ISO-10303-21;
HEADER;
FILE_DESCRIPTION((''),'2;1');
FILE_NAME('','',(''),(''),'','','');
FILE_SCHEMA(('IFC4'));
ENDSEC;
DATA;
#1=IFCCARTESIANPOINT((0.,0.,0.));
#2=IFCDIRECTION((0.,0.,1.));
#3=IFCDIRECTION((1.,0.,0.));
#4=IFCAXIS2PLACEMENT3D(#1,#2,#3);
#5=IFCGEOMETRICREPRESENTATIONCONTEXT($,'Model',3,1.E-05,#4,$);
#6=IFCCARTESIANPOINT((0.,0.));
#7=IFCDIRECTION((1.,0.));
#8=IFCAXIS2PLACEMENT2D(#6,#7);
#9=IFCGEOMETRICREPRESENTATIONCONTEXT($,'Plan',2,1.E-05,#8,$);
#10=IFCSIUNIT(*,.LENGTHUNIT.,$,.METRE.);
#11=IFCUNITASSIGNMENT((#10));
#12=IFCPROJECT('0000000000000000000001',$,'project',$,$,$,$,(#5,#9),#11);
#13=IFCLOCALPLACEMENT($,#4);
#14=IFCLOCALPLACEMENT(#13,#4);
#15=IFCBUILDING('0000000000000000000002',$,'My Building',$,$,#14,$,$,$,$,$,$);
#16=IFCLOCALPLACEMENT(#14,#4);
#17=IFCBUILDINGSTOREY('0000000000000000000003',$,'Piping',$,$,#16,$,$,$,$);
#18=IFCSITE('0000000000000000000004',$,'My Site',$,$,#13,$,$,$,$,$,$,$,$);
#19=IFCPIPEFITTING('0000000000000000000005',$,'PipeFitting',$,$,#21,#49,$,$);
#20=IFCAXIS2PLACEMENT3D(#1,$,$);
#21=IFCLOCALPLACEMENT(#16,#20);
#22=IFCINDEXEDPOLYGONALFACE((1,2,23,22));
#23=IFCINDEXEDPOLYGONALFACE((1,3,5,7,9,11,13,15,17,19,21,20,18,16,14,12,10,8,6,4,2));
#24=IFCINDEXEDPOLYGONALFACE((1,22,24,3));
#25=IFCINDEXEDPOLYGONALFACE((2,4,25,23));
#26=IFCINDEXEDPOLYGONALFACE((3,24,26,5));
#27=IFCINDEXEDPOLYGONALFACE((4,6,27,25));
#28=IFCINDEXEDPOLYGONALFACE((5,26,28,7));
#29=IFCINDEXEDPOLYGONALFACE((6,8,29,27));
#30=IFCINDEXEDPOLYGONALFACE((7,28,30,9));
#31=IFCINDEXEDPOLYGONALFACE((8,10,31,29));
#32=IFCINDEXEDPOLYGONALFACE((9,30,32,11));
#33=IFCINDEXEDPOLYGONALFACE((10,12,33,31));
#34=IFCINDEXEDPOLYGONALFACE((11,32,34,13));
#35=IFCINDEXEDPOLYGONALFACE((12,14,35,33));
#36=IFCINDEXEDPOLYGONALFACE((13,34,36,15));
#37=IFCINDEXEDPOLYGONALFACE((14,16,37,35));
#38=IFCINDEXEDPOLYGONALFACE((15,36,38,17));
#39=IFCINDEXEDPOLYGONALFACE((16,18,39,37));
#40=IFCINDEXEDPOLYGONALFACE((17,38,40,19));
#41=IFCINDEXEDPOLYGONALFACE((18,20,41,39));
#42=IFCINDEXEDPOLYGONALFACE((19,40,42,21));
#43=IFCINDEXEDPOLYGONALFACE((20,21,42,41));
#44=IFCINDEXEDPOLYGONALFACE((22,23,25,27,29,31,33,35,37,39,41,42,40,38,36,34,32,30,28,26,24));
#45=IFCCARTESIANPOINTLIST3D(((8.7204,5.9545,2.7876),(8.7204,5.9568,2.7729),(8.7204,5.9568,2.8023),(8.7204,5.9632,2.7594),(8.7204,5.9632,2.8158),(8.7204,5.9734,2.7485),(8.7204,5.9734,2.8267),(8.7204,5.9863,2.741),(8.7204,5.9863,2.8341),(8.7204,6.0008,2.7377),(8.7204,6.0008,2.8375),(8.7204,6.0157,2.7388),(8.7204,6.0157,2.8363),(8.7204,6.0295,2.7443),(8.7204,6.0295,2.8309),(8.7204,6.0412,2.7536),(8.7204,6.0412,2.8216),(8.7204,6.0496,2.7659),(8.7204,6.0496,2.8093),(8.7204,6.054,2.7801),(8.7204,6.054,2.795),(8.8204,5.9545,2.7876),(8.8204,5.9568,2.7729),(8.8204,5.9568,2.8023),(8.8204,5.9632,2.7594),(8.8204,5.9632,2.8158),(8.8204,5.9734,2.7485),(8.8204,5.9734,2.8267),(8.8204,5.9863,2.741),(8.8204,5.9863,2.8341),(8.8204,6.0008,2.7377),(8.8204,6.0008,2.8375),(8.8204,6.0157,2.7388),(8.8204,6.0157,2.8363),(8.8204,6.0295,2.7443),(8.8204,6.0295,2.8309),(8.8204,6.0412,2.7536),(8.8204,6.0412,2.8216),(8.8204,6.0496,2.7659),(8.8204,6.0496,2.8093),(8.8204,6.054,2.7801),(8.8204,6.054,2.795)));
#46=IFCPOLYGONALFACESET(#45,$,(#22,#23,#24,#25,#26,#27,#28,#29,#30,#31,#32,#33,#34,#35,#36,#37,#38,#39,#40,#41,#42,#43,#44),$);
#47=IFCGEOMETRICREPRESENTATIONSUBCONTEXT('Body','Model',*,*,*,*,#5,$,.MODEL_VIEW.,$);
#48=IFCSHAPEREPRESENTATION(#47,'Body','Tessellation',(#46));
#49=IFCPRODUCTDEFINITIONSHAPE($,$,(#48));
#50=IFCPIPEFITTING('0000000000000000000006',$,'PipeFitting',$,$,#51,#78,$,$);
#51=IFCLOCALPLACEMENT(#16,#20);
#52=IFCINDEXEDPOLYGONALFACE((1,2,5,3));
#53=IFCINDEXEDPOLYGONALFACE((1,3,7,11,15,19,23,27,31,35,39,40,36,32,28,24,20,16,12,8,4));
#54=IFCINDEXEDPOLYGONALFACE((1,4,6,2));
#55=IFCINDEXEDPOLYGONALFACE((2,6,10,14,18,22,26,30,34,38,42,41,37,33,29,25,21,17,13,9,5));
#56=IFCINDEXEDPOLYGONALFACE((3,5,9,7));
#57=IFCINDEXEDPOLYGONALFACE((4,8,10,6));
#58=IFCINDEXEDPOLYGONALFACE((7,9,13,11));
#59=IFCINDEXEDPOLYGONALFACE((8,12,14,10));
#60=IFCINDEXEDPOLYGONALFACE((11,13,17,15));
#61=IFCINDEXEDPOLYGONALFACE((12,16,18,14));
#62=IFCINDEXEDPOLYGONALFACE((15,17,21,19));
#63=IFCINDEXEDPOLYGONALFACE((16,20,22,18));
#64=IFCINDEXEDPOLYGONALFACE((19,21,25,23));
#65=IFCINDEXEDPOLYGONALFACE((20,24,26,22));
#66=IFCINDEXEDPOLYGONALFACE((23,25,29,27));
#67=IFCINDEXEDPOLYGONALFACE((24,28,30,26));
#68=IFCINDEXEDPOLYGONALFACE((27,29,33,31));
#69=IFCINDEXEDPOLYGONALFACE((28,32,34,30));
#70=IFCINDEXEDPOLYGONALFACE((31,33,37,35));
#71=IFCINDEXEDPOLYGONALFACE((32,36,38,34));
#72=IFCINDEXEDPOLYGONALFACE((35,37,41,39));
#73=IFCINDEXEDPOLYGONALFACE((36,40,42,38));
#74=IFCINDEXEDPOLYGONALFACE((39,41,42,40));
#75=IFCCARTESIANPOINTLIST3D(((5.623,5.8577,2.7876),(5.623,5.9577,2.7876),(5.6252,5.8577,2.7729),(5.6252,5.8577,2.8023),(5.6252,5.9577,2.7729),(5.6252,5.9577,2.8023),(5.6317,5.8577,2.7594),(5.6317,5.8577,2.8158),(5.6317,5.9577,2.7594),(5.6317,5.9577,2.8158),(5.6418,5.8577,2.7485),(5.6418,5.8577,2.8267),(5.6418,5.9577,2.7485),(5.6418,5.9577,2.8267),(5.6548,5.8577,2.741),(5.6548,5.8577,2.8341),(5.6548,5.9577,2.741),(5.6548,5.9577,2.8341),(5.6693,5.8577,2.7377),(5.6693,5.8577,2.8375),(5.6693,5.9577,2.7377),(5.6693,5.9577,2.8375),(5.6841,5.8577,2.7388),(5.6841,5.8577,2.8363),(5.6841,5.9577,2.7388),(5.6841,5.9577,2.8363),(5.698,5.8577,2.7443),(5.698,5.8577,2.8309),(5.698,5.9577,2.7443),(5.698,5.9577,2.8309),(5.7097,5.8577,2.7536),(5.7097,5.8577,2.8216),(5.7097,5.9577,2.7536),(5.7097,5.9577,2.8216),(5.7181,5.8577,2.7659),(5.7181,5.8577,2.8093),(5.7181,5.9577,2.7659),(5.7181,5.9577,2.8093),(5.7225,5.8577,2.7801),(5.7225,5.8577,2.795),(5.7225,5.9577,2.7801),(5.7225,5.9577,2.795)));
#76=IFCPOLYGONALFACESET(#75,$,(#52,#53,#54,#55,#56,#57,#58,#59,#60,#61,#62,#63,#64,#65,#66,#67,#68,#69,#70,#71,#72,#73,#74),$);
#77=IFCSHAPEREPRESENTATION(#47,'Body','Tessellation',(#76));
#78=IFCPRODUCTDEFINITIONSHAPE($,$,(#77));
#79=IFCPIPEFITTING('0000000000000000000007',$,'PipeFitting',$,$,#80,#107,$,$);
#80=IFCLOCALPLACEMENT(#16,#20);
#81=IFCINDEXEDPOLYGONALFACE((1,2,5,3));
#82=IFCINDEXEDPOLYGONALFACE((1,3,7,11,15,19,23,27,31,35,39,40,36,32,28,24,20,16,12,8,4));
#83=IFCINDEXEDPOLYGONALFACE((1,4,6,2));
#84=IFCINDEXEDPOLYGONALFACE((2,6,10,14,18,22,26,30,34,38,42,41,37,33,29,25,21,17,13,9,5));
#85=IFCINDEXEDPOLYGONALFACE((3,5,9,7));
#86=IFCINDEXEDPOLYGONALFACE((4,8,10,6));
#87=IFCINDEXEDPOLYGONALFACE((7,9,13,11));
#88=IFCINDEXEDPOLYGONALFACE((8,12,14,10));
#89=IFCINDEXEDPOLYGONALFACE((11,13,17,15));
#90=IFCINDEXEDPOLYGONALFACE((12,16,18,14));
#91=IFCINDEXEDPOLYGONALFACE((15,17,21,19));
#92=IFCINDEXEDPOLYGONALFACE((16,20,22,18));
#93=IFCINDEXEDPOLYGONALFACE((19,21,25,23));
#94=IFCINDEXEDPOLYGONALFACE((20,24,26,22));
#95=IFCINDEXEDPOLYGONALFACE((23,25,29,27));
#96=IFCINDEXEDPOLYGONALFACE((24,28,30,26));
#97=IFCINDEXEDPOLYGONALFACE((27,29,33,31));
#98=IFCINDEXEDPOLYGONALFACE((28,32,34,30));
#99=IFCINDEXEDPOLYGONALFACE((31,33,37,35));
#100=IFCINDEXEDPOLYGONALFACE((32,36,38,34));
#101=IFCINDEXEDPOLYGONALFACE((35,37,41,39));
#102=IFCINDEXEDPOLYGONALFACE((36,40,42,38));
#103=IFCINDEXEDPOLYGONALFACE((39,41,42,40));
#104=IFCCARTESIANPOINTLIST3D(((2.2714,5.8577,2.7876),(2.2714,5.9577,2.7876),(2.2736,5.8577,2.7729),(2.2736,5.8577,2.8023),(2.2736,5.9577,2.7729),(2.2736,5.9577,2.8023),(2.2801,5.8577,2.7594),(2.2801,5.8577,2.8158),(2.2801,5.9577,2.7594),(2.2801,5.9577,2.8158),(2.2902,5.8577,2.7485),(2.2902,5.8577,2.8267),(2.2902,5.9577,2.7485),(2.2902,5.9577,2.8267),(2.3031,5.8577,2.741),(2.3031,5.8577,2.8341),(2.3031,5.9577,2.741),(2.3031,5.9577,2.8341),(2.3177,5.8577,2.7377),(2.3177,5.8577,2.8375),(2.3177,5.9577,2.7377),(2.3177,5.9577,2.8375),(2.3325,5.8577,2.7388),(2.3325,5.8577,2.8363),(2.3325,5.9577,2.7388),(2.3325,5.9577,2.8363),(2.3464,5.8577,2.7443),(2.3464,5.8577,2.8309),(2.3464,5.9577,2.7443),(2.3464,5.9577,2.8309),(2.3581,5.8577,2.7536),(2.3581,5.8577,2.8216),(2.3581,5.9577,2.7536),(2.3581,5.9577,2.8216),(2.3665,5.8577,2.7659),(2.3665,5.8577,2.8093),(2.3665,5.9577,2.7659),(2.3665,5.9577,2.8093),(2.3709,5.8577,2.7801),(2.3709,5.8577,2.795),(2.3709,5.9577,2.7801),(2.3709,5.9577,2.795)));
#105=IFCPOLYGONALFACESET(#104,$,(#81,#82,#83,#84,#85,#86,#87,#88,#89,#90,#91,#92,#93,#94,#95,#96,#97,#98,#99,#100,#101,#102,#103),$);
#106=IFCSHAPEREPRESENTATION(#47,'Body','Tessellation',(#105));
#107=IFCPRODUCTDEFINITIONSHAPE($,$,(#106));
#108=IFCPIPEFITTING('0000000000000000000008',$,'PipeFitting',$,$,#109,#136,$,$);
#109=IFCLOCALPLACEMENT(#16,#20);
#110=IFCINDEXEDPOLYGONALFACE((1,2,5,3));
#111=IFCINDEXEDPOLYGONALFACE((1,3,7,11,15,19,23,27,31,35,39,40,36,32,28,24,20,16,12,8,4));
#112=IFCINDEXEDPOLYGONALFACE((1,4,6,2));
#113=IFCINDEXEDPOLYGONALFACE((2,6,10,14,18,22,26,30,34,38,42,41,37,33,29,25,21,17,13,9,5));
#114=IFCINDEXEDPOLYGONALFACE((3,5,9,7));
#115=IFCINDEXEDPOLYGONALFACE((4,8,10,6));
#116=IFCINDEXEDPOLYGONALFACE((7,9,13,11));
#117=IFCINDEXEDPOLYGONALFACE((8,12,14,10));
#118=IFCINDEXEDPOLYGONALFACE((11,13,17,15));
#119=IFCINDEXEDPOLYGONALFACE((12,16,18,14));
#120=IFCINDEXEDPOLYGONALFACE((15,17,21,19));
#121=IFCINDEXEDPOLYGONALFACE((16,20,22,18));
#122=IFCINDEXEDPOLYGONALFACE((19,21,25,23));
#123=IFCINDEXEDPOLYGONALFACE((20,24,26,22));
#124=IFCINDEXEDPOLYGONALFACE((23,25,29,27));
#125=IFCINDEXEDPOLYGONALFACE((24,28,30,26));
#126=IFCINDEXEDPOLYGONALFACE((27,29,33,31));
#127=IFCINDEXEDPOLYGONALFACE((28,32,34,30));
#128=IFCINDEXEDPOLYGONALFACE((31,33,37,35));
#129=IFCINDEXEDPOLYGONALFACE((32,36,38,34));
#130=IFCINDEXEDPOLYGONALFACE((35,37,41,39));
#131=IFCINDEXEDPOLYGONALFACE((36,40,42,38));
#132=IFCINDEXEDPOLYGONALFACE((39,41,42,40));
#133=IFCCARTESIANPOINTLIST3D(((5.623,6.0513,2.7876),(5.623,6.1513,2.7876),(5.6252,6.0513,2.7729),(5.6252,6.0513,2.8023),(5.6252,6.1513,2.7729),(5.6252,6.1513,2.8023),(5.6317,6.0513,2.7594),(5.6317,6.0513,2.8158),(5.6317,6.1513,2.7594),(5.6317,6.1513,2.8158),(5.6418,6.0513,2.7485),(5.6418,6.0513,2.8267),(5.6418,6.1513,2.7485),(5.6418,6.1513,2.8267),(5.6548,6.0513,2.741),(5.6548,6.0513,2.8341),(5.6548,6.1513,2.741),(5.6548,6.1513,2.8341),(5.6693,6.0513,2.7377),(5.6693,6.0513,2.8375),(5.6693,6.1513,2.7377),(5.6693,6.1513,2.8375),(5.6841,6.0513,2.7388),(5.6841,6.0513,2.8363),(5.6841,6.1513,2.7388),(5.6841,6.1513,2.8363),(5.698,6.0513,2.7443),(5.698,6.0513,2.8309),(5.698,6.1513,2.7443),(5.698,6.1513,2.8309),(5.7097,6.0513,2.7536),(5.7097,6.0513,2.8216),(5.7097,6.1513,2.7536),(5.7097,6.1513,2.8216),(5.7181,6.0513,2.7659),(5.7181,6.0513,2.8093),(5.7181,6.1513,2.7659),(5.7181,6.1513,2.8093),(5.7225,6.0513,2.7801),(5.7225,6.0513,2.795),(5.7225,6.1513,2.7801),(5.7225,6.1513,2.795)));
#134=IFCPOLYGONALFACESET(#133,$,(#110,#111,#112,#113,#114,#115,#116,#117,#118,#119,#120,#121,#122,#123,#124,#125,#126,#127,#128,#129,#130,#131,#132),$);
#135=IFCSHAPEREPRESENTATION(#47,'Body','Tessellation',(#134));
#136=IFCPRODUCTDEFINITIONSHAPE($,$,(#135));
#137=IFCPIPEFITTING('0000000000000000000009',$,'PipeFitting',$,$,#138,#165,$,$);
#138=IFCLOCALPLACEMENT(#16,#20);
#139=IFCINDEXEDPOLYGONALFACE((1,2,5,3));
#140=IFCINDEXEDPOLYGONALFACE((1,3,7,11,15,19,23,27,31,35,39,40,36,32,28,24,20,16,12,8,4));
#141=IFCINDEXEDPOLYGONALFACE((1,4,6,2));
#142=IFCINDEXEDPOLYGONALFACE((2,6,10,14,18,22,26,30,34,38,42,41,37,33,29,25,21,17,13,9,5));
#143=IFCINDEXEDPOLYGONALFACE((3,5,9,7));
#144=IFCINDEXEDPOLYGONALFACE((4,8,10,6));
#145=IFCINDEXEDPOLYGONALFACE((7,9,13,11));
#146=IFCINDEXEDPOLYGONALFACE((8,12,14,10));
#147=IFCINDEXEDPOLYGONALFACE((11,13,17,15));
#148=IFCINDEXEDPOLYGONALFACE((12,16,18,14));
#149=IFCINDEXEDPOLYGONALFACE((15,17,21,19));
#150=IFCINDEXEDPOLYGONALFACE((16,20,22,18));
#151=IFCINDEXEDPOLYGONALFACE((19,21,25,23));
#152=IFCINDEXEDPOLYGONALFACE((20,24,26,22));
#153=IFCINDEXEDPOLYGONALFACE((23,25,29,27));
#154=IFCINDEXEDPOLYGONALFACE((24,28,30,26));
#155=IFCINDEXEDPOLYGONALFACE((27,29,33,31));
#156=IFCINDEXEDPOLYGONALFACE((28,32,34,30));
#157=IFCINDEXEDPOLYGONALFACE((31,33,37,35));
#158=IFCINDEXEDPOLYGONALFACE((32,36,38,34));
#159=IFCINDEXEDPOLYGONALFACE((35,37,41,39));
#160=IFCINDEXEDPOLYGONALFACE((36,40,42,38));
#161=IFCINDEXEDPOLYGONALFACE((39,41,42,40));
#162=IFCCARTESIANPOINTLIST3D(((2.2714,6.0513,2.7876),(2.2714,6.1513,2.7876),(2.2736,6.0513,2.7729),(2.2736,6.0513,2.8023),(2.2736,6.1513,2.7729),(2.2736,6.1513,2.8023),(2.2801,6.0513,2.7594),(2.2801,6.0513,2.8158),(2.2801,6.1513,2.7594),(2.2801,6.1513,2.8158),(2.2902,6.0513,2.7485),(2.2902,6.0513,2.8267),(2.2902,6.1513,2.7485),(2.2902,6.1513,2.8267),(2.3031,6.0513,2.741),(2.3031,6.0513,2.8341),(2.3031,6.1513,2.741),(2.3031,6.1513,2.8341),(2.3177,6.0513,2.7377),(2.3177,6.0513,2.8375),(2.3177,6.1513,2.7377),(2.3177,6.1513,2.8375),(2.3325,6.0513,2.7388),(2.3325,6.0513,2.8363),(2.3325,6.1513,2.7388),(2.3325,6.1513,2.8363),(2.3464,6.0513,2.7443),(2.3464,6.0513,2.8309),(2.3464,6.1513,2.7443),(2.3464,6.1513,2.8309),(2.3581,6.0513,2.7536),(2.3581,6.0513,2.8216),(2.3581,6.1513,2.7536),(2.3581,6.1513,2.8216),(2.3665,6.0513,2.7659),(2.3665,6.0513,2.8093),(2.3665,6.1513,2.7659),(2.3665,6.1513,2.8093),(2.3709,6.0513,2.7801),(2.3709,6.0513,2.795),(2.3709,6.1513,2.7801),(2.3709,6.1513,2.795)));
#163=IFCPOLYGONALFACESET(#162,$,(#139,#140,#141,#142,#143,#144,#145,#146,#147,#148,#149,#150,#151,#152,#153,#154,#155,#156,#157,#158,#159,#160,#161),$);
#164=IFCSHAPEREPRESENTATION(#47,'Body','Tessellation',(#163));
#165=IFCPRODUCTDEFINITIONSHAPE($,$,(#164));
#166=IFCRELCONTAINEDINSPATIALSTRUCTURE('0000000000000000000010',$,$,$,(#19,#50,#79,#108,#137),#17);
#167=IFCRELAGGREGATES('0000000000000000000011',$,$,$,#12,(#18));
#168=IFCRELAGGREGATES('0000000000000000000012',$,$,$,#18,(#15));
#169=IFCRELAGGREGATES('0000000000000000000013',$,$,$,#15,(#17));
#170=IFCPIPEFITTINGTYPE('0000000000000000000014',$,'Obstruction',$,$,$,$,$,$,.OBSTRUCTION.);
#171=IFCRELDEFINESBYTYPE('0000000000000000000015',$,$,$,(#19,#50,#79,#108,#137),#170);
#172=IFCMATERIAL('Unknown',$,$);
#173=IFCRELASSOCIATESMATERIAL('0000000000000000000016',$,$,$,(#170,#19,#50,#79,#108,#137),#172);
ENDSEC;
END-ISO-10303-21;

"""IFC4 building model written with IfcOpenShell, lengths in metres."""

from ifc_helpers import new_model, si_unit, frame, origin_with_axes, origin_2d_with_axis, place, context, subcontext, project, spatial, circle, extrude, material, material_profile, profile_set, profile_usage, type_object, element, save


model = new_model("IFC4")

# Units and contexts
model_context = context("Model", 3, precision=1e-05, world=origin_with_axes())
plan_context = context("Plan", 2, precision=1e-05, world=origin_2d_with_axis())
body_context = subcontext(model_context, "Body", "Model", "MODEL_VIEW")
ifc_project = project(units=[si_unit("LENGTHUNIT", "METRE")], contexts=[model_context, plan_context])

# Site, building, storey
site_placement = place(None, origin_with_axes())
site = spatial("IfcSite", under=ifc_project, at=site_placement, Name="My Site")
building_placement = place(site_placement, origin_with_axes())
building = spatial("IfcBuilding", under=site, at=building_placement, Name="My Building")
storey_placement = place(building_placement, origin_with_axes())
storey = spatial("IfcBuildingStorey", under=building, at=storey_placement, Name="Piping")

# Shared definitions
ifc_material = material(Name="Unknown")

# Pipe fittings
ifc_material_profile_1 = material_profile(ifc_material, circle(Radius=0.05))
ifc_profile_set_1 = profile_set([ifc_material_profile_1])
ifc_profile_usage_1 = profile_usage(ifc_profile_set_1, cardinal=5)
pipe_fitting_type = type_object("IfcPipeFittingType", Name="Obstruction", PredefinedType="OBSTRUCTION", material=ifc_profile_set_1)
pipe_fitting_1_placement = place(storey_placement, frame((8.8204, 6.0045, 2.7876), z_axis=(-1.0, 0.0, 0.0), x_axis=(0.0, -1.0, 0.0)))
element("IfcPipeFitting", 1, at=pipe_fitting_1_placement, inside=storey, type_object=pipe_fitting_type, material=ifc_profile_usage_1, Name="PipeFitting", context=body_context, shape_type="SweptSolid", body=[
    extrude(circle(Radius=0.05), origin_with_axes(), (0.0, 0.0, 1.0), 0.1),
])
ifc_profile_usage_2 = profile_usage(ifc_profile_set_1, cardinal=5)
pipe_fitting_2_placement = place(storey_placement, frame((5.673, 5.8577, 2.7876), z_axis=(0.0, 1.0, 0.0), x_axis=(-1.0, 0.0, 0.0)))
element("IfcPipeFitting", 2, at=pipe_fitting_2_placement, inside=storey, type_object=pipe_fitting_type, material=ifc_profile_usage_2, Name="PipeFitting", context=body_context, shape_type="SweptSolid", body=[
    extrude(circle(Radius=0.05), origin_with_axes(), (0.0, 0.0, 1.0), 0.1),
])
ifc_profile_usage_3 = profile_usage(ifc_profile_set_1, cardinal=5)
pipe_fitting_3_placement = place(storey_placement, frame((2.3214, 5.8577, 2.7876), z_axis=(0.0, 1.0, 0.0), x_axis=(-1.0, 0.0, 0.0)))
element("IfcPipeFitting", 3, at=pipe_fitting_3_placement, inside=storey, type_object=pipe_fitting_type, material=ifc_profile_usage_3, Name="PipeFitting", context=body_context, shape_type="SweptSolid", body=[
    extrude(circle(Radius=0.05), origin_with_axes(), (0.0, 0.0, 1.0), 0.1),
])
ifc_profile_usage_4 = profile_usage(ifc_profile_set_1, cardinal=5)
pipe_fitting_4_placement = place(storey_placement, frame((5.673, 6.0513, 2.7876), z_axis=(0.0, 1.0, 0.0), x_axis=(-1.0, 0.0, 0.0)))
element("IfcPipeFitting", 4, at=pipe_fitting_4_placement, inside=storey, type_object=pipe_fitting_type, material=ifc_profile_usage_4, Name="PipeFitting", context=body_context, shape_type="SweptSolid", body=[
    extrude(circle(Radius=0.05), origin_with_axes(), (0.0, 0.0, 1.0), 0.1),
])
ifc_profile_usage_5 = profile_usage(ifc_profile_set_1, cardinal=5)
pipe_fitting_5_placement = place(storey_placement, frame((2.3214, 6.0513, 2.7876), z_axis=(0.0, 1.0, 0.0), x_axis=(-1.0, 0.0, 0.0)))
element("IfcPipeFitting", 5, at=pipe_fitting_5_placement, inside=storey, type_object=pipe_fitting_type, material=ifc_profile_usage_5, Name="PipeFitting", context=body_context, shape_type="SweptSolid", body=[
    extrude(circle(Radius=0.05), origin_with_axes(), (0.0, 0.0, 1.0), 0.1),
])

save(model, "model.ifc")
